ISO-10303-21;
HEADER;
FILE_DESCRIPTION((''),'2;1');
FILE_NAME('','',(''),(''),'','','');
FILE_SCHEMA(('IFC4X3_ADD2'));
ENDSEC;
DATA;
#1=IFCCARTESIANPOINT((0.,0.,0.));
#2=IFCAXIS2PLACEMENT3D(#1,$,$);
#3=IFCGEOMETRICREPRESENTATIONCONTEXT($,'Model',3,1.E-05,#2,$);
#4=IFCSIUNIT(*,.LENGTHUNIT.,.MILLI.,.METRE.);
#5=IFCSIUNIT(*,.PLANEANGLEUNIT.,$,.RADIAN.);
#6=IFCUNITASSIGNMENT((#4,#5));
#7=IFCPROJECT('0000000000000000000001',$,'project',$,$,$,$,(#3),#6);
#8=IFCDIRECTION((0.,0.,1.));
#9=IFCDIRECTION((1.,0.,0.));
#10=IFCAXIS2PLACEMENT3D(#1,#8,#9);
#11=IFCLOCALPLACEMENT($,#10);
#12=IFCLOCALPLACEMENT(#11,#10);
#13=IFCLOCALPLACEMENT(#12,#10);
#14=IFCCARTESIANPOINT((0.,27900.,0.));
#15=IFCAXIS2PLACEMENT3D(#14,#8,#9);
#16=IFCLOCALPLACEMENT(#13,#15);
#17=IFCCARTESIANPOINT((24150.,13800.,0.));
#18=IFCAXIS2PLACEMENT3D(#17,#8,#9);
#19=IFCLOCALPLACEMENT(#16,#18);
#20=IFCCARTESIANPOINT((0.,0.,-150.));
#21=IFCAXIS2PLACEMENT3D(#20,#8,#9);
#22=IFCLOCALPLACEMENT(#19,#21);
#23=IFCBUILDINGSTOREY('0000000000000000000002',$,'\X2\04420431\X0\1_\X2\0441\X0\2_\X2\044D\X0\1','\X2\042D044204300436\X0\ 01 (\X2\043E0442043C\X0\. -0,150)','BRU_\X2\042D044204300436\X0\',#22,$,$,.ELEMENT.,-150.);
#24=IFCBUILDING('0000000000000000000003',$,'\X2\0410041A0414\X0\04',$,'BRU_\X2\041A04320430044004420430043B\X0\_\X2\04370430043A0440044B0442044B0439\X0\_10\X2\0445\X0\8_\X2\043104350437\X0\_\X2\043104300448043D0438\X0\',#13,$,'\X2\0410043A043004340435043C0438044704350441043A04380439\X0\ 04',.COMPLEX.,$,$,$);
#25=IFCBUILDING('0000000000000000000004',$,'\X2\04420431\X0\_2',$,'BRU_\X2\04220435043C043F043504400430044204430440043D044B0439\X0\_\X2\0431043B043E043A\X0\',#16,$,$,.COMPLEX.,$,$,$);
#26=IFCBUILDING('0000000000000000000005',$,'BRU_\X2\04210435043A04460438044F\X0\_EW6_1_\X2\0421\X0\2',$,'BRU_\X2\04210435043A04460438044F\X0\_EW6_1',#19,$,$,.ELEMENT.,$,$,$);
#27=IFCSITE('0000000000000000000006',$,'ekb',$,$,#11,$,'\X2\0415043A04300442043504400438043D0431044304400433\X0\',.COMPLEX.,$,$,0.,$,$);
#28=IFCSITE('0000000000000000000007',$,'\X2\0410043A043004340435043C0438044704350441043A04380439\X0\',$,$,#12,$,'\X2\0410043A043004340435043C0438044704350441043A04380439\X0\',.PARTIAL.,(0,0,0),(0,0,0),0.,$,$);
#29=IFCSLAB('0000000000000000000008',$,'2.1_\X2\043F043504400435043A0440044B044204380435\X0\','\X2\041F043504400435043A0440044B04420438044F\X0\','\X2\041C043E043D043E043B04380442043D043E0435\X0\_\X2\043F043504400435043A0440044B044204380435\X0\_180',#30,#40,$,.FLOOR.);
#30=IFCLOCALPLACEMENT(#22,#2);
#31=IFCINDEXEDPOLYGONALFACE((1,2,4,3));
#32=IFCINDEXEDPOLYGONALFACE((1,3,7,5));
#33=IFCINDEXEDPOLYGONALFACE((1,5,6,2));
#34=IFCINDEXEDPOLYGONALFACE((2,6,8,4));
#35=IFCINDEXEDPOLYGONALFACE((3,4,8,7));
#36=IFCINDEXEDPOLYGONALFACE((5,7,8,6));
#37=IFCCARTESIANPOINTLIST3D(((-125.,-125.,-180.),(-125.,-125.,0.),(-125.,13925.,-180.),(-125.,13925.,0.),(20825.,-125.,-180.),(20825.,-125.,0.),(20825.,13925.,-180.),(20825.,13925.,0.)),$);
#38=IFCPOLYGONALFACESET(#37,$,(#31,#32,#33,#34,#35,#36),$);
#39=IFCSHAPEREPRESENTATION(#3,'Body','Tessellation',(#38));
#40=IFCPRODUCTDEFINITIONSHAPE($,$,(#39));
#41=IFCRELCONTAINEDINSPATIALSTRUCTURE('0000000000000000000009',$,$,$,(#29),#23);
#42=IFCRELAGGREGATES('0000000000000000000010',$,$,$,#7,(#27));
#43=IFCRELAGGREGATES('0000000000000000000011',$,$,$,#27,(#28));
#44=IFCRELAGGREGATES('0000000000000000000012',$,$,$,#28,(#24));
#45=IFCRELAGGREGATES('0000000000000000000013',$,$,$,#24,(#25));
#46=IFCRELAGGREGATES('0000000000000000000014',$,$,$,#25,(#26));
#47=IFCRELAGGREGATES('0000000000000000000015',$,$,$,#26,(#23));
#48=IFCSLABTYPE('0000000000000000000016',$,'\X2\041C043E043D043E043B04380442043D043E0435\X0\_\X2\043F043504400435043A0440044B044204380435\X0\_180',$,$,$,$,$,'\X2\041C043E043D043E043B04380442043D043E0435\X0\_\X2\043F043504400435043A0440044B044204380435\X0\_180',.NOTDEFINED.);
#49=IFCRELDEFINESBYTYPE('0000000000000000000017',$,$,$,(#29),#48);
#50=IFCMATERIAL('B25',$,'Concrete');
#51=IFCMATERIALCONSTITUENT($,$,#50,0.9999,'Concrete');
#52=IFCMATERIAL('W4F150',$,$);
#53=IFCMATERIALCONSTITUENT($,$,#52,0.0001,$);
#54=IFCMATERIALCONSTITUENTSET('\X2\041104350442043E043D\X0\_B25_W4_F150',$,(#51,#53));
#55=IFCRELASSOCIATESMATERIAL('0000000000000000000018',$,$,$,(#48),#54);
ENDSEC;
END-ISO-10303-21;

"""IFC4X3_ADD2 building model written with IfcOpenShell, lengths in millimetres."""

from ifc_helpers import new_model, si_unit, frame, origin, origin_with_axes, place, context, project, spatial, polyline, outline, extrude, material, constituent, constituent_set, type_object, element, save


model = new_model("IFC4X3_ADD2")

# Units and contexts
model_context = context("Model", 3, precision=1e-05, world=origin())
ifc_project = project(units=[si_unit("LENGTHUNIT", "METRE", prefix="MILLI"), si_unit("PLANEANGLEUNIT", "RADIAN")], contexts=[model_context])

# Sites, buildings, storey
site_1_placement = place(None, origin_with_axes())
site_1 = spatial("IfcSite", under=ifc_project, at=site_1_placement, Name="ekb", LongName="Екатеринбург", CompositionType="COMPLEX", RefElevation=0.0)
site_2_placement = place(site_1_placement, origin_with_axes())
site_2 = spatial("IfcSite", under=site_1, at=site_2_placement, Name="Академический", LongName="Академический", CompositionType="PARTIAL", RefLatitude=(0, 0, 0), RefLongitude=(0, 0, 0), RefElevation=0.0)
building_1_placement = place(site_2_placement, origin_with_axes())
building_1 = spatial("IfcBuilding", under=site_2, at=building_1_placement, Name="АКД04", ObjectType="BRU_Квартал_закрытый_10х8_без_башни", LongName="Академический 04", CompositionType="COMPLEX")
building_2_placement = place(building_1_placement, frame((0.0, 27900.0, 0.0), z_axis=(0.0, 0.0, 1.0), x_axis=(1.0, 0.0, 0.0)))
building_2 = spatial("IfcBuilding", under=building_1, at=building_2_placement, Name="тб_2", ObjectType="BRU_Температурный_блок", CompositionType="COMPLEX")
building_3_placement = place(building_2_placement, frame((24150.0, 13800.0, 0.0), z_axis=(0.0, 0.0, 1.0), x_axis=(1.0, 0.0, 0.0)))
building_3 = spatial("IfcBuilding", under=building_2, at=building_3_placement, Name="BRU_Секция_EW6_1_С2", ObjectType="BRU_Секция_EW6_1", CompositionType="ELEMENT")
storey_placement = place(building_3_placement, frame((0.0, 0.0, -150.0), z_axis=(0.0, 0.0, 1.0), x_axis=(1.0, 0.0, 0.0)))
storey = spatial("IfcBuildingStorey", under=building_3, at=storey_placement, Name="тб1_с2_э1", Description="Этаж 01 (отм. -0,150)", ObjectType="BRU_Этаж", CompositionType="ELEMENT", Elevation=-150.0)

# Shared definitions
ifc_material_1 = material(Name="B25", Category="Concrete")
ifc_material_2 = material(Name="W4F150")

# Slab
ifc_constituent_1 = constituent(ifc_material_1, Category="Concrete", fraction=0.9999)
ifc_constituent_2 = constituent(ifc_material_2, fraction=0.0001)
ifc_constituent_set_1 = constituent_set(constituents=[ifc_constituent_1, ifc_constituent_2], Name="Бетон_B25_W4_F150")
slab_type = type_object("IfcSlabType", Name="Монолитное_перекрытие_180", ElementType="Монолитное_перекрытие_180", PredefinedType="NOTDEFINED", material=ifc_constituent_set_1)
slab_placement = place(storey_placement, frame((0.0, 0.0, -180.0), z_axis=(0.0, 0.0, 1.0), x_axis=(1.0, 0.0, 0.0)))
element("IfcSlab", 1, at=slab_placement, inside=storey, type_object=slab_type, Name="2.1_перекрытие", Description="Перекрытия", ObjectType="Монолитное_перекрытие_180", PredefinedType="FLOOR", context=model_context, shape_type="SweptSolid", body=[
    extrude(outline(polyline([(-125.0, -125.0), (20825.0, -125.0), (20825.0, 13925.0), (-125.0, 13925.0), (-125.0, -125.0)])), origin_with_axes(), (0.0, 0.0, 1.0), 180.0),
])

save(model, "model.ifc")
